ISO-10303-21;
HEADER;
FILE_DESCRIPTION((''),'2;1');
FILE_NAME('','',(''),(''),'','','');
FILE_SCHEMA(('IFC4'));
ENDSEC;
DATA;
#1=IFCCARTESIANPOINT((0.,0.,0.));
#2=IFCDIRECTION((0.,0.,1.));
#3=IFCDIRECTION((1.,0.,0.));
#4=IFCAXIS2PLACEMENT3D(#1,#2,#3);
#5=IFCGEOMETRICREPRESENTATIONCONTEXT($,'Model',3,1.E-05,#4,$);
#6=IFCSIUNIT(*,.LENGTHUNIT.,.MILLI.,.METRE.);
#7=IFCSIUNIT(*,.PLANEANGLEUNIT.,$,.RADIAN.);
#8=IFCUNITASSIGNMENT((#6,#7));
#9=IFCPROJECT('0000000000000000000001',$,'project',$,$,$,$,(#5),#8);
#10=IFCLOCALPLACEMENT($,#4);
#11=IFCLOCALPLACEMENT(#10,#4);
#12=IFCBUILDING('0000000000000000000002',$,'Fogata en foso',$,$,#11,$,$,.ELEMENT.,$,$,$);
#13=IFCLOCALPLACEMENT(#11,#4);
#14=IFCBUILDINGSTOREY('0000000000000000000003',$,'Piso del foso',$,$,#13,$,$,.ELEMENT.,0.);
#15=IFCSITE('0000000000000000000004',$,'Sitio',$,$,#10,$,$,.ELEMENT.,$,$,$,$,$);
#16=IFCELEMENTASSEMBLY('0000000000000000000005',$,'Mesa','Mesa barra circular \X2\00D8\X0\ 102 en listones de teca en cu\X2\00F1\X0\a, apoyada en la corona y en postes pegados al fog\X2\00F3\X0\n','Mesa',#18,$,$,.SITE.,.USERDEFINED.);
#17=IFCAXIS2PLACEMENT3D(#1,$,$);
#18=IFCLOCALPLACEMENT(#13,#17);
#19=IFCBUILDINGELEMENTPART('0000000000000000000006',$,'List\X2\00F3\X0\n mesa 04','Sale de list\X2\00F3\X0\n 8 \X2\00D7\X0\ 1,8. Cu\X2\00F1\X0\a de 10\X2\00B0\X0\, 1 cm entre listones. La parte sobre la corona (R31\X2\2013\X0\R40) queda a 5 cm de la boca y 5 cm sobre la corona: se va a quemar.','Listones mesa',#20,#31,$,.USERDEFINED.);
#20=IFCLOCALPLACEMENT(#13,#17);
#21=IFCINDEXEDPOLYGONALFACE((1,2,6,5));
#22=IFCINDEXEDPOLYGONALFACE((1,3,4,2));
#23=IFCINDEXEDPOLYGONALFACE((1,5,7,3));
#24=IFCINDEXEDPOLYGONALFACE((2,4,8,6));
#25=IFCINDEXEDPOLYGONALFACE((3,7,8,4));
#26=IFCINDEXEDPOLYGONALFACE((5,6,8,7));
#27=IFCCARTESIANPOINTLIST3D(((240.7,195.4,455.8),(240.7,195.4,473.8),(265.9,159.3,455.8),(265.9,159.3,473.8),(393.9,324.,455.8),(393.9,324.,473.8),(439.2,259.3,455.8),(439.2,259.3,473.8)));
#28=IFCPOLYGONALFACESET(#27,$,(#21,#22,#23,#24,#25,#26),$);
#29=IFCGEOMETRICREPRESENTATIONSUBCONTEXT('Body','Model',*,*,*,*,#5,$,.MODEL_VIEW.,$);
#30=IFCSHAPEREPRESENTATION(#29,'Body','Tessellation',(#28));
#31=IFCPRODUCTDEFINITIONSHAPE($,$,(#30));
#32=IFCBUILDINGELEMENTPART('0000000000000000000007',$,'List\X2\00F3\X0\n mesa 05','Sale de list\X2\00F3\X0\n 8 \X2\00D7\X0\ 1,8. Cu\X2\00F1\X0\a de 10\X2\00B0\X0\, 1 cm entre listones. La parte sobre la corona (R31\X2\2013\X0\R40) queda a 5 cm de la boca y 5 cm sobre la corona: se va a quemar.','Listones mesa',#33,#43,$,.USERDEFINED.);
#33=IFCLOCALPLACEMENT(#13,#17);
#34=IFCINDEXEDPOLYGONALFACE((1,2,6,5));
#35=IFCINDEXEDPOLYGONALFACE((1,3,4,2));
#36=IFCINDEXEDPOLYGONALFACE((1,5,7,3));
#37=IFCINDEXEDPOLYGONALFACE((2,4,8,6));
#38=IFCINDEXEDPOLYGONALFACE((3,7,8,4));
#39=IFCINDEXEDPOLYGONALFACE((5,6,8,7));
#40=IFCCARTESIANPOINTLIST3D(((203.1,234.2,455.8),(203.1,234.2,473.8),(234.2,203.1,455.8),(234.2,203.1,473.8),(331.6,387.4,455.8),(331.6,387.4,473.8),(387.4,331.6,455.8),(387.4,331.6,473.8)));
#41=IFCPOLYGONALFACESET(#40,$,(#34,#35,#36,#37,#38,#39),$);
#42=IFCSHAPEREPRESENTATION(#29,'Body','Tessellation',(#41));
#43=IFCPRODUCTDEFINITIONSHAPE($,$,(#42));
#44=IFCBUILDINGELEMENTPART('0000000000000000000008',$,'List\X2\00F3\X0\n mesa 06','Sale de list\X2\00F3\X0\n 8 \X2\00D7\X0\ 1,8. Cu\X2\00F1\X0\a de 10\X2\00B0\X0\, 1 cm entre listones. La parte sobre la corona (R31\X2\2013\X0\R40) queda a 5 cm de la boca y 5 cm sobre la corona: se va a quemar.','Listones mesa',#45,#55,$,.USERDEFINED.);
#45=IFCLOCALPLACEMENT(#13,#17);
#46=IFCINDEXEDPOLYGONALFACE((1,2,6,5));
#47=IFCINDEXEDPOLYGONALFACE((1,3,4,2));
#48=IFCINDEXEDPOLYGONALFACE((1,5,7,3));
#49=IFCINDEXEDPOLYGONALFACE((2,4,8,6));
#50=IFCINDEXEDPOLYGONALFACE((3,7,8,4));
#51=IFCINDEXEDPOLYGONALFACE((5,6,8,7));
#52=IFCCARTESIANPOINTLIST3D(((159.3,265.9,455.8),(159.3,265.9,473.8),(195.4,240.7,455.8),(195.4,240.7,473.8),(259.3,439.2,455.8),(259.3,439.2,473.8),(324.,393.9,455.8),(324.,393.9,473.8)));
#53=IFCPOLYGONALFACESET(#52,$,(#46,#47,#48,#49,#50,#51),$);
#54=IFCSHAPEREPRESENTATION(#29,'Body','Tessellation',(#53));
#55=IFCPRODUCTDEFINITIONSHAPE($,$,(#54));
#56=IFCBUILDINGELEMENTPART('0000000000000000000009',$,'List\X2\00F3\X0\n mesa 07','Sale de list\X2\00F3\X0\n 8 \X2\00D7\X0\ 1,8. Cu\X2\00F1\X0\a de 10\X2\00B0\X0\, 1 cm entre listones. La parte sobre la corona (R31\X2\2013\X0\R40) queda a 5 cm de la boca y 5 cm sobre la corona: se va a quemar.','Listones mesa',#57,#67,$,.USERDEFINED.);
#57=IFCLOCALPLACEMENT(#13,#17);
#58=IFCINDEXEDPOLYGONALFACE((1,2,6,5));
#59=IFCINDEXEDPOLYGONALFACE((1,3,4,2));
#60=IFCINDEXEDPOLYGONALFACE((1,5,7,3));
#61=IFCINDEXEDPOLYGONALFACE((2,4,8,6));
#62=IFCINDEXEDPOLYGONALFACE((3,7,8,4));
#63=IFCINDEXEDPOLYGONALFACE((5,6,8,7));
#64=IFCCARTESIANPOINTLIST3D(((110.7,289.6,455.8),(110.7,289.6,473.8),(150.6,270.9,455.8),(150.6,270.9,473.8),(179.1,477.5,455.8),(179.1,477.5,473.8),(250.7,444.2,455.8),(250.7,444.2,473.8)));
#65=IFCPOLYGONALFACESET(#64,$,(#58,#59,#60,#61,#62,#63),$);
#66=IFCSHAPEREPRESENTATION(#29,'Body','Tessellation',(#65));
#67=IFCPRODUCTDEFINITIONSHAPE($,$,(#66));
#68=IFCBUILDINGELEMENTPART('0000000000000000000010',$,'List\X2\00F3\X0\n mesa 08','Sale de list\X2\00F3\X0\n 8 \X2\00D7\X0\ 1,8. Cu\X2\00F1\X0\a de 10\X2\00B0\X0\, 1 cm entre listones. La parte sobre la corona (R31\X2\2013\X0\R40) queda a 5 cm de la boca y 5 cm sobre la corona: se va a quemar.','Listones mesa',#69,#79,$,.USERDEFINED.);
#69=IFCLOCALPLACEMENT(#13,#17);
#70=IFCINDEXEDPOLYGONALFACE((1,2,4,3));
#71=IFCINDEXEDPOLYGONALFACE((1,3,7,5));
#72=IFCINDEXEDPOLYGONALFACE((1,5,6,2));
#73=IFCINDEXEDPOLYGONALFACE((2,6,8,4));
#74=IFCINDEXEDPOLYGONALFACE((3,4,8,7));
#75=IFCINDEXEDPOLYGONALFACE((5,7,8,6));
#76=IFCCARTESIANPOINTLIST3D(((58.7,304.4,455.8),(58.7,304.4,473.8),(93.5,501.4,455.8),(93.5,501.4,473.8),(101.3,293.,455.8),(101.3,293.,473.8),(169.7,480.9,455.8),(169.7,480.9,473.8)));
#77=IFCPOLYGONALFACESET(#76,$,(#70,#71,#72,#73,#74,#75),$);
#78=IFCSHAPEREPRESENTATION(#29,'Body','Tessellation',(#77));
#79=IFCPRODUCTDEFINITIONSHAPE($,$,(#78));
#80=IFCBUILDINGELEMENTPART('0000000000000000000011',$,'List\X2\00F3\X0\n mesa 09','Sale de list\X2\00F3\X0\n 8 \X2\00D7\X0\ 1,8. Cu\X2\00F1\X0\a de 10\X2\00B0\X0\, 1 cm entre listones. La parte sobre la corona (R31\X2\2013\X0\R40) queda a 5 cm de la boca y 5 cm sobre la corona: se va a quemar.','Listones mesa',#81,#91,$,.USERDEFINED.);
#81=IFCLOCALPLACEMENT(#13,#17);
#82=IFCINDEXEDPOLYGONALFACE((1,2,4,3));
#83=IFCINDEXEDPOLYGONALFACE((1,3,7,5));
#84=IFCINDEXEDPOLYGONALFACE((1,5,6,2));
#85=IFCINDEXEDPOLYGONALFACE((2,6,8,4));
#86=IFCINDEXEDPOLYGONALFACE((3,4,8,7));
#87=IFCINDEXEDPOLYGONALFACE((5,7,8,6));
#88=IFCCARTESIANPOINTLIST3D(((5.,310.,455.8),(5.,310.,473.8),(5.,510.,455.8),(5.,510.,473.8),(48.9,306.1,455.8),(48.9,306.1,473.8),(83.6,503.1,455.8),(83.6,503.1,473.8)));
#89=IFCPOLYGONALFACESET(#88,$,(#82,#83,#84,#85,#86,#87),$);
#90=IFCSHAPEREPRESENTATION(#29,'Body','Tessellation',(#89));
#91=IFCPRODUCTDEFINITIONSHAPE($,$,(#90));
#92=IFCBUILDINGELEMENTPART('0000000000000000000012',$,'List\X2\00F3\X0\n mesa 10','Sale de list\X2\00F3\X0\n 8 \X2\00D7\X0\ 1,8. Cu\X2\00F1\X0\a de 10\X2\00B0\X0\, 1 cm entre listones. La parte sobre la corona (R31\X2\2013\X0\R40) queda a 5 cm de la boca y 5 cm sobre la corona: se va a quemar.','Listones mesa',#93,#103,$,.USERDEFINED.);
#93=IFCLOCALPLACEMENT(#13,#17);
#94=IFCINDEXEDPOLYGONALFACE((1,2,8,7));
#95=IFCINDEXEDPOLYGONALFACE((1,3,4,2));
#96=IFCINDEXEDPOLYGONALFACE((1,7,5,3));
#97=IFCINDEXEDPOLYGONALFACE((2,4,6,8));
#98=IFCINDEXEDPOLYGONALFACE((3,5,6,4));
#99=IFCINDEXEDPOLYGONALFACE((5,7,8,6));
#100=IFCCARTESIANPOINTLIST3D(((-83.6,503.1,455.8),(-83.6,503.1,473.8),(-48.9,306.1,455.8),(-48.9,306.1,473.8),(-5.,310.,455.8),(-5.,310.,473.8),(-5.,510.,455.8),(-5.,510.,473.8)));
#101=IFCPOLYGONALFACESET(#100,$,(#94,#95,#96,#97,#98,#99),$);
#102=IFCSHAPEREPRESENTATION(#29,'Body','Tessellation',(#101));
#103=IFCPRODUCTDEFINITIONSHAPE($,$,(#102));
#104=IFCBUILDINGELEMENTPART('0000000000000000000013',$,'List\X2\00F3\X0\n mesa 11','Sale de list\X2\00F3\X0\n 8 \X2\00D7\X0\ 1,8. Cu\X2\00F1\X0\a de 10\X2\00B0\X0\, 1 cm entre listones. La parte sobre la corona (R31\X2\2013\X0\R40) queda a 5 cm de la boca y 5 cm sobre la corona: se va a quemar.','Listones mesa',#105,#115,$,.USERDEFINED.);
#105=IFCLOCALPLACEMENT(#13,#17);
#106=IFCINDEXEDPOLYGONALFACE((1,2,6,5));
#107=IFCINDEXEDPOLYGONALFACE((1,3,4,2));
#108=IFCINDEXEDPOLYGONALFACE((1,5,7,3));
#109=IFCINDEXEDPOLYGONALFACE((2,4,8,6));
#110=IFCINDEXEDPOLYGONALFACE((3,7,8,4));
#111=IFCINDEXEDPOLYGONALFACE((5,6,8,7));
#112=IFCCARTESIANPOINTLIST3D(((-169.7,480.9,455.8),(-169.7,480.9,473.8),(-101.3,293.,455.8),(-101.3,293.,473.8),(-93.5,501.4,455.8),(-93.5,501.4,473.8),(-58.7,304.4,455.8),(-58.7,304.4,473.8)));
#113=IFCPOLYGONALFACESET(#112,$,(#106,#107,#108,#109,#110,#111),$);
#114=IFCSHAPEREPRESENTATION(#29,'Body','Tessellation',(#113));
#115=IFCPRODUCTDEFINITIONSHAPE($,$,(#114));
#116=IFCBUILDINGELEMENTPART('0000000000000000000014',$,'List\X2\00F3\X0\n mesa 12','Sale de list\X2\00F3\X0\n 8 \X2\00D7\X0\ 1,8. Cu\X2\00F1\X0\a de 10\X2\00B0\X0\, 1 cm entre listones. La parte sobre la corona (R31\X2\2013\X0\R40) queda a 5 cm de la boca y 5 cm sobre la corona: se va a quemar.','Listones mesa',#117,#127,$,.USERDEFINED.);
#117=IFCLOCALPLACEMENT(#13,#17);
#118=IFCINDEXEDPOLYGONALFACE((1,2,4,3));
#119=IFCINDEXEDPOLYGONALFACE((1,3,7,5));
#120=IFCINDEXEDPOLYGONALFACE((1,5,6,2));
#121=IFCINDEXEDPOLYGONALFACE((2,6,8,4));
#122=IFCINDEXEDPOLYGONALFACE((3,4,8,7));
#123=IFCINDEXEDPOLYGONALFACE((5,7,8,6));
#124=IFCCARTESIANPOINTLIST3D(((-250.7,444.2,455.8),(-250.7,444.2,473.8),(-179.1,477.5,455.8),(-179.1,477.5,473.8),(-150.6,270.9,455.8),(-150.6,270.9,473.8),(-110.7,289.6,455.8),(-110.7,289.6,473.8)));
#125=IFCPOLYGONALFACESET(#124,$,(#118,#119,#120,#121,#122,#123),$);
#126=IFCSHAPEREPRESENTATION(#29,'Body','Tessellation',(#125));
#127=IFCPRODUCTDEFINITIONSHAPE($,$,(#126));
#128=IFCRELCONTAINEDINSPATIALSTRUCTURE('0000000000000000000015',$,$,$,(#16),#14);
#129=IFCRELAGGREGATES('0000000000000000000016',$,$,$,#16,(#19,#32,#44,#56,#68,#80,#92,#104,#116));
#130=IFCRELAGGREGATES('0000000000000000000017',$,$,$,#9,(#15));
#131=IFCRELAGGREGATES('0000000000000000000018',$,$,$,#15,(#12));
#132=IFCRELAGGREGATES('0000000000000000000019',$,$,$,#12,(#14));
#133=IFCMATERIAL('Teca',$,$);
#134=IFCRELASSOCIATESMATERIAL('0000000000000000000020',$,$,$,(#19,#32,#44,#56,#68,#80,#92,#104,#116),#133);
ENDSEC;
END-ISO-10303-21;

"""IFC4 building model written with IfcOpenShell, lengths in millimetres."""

from ifc_helpers import new_model, si_unit, frame, origin_with_axes, place, context, subcontext, project, spatial, polyline, outline, extrude, material, element, aggregate, save


model = new_model("IFC4")

# Units and contexts
model_context = context("Model", 3, precision=1e-05, world=origin_with_axes())
body_context = subcontext(model_context, "Body", "Model", "MODEL_VIEW")
ifc_project = project(units=[si_unit("LENGTHUNIT", "METRE", prefix="MILLI"), si_unit("PLANEANGLEUNIT", "RADIAN")], contexts=[model_context])

# Site, building, storey
site_placement = place(None, origin_with_axes())
site = spatial("IfcSite", under=ifc_project, at=site_placement, Name="Sitio", CompositionType="ELEMENT")
building_placement = place(site_placement, origin_with_axes())
building = spatial("IfcBuilding", under=site, at=building_placement, Name="Fogata en foso", CompositionType="ELEMENT")
storey_placement = place(building_placement, origin_with_axes())
storey = spatial("IfcBuildingStorey", under=building, at=storey_placement, Name="Piso del foso", CompositionType="ELEMENT", Elevation=0.0)

# Element assembly
assembly_1_placement = place(storey_placement, origin_with_axes())
assembly_1 = element("IfcElementAssembly", 1, at=assembly_1_placement, inside=storey, Name="Mesa", Description="Mesa barra circular Ø 102 en listones de teca en cuña, apoyada en la corona y en postes pegados al fogón", ObjectType="Mesa", AssemblyPlace="SITE", PredefinedType="USERDEFINED")

# Building element parts
ifc_material_1 = material(Name="Teca")
building_element_part_1_placement = place(storey_placement, frame((0.0, 0.0, 455.8), z_axis=(0.0, 0.0, 1.0), x_axis=(1.0, 0.0, 0.0)))
building_element_part_1 = element("IfcBuildingElementPart", 2, at=building_element_part_1_placement, material=ifc_material_1, Name="Listón mesa 04", Description="Sale de listón 8 × 1,8. Cuña de 10°, 1 cm entre listones. La parte sobre la corona (R31–R40) queda a 5 cm de la boca y 5 cm sobre la corona: se va a quemar.", ObjectType="Listones mesa", PredefinedType="USERDEFINED", context=body_context, shape_type="SweptSolid", body=[
    extrude(outline(polyline([(265.9, 159.3), (439.2, 259.3), (393.9, 324.0), (240.7, 195.4), (265.9, 159.3)])), origin_with_axes(), (0.0, 0.0, 1.0), 18.0),
])
building_element_part_2_placement = place(storey_placement, frame((0.0, 0.0, 455.8), z_axis=(0.0, 0.0, 1.0), x_axis=(1.0, 0.0, 0.0)))
building_element_part_2 = element("IfcBuildingElementPart", 3, at=building_element_part_2_placement, material=ifc_material_1, Name="Listón mesa 05", Description="Sale de listón 8 × 1,8. Cuña de 10°, 1 cm entre listones. La parte sobre la corona (R31–R40) queda a 5 cm de la boca y 5 cm sobre la corona: se va a quemar.", ObjectType="Listones mesa", PredefinedType="USERDEFINED", context=body_context, shape_type="SweptSolid", body=[
    extrude(outline(polyline([(234.2, 203.1), (387.4, 331.6), (331.6, 387.4), (203.1, 234.2), (234.2, 203.1)])), origin_with_axes(), (0.0, 0.0, 1.0), 18.0),
])
building_element_part_3_placement = place(storey_placement, frame((0.0, 0.0, 455.8), z_axis=(0.0, 0.0, 1.0), x_axis=(1.0, 0.0, 0.0)))
building_element_part_3 = element("IfcBuildingElementPart", 4, at=building_element_part_3_placement, material=ifc_material_1, Name="Listón mesa 06", Description="Sale de listón 8 × 1,8. Cuña de 10°, 1 cm entre listones. La parte sobre la corona (R31–R40) queda a 5 cm de la boca y 5 cm sobre la corona: se va a quemar.", ObjectType="Listones mesa", PredefinedType="USERDEFINED", context=body_context, shape_type="SweptSolid", body=[
    extrude(outline(polyline([(195.4, 240.7), (324.0, 393.9), (259.3, 439.2), (159.3, 265.9), (195.4, 240.7)])), origin_with_axes(), (0.0, 0.0, 1.0), 18.0),
])
building_element_part_4_placement = place(storey_placement, frame((0.0, 0.0, 455.8), z_axis=(0.0, 0.0, 1.0), x_axis=(1.0, 0.0, 0.0)))
building_element_part_4 = element("IfcBuildingElementPart", 5, at=building_element_part_4_placement, material=ifc_material_1, Name="Listón mesa 07", Description="Sale de listón 8 × 1,8. Cuña de 10°, 1 cm entre listones. La parte sobre la corona (R31–R40) queda a 5 cm de la boca y 5 cm sobre la corona: se va a quemar.", ObjectType="Listones mesa", PredefinedType="USERDEFINED", context=body_context, shape_type="SweptSolid", body=[
    extrude(outline(polyline([(150.7, 270.9), (250.7, 444.2), (179.1, 477.5), (110.7, 289.6), (150.7, 270.9)])), origin_with_axes(), (0.0, 0.0, 1.0), 18.0),
])
building_element_part_5_placement = place(storey_placement, frame((0.0, 0.0, 455.8), z_axis=(0.0, 0.0, 1.0), x_axis=(1.0, 0.0, 0.0)))
building_element_part_5 = element("IfcBuildingElementPart", 6, at=building_element_part_5_placement, material=ifc_material_1, Name="Listón mesa 08", Description="Sale de listón 8 × 1,8. Cuña de 10°, 1 cm entre listones. La parte sobre la corona (R31–R40) queda a 5 cm de la boca y 5 cm sobre la corona: se va a quemar.", ObjectType="Listones mesa", PredefinedType="USERDEFINED", context=body_context, shape_type="SweptSolid", body=[
    extrude(outline(polyline([(101.3, 293.0), (169.7, 480.9), (93.5, 501.4), (58.7, 304.4), (101.3, 293.0)])), origin_with_axes(), (0.0, 0.0, 1.0), 18.0),
])
building_element_part_6_placement = place(storey_placement, frame((0.0, 0.0, 455.8), z_axis=(0.0, 0.0, 1.0), x_axis=(1.0, 0.0, 0.0)))
building_element_part_6 = element("IfcBuildingElementPart", 7, at=building_element_part_6_placement, material=ifc_material_1, Name="Listón mesa 09", Description="Sale de listón 8 × 1,8. Cuña de 10°, 1 cm entre listones. La parte sobre la corona (R31–R40) queda a 5 cm de la boca y 5 cm sobre la corona: se va a quemar.", ObjectType="Listones mesa", PredefinedType="USERDEFINED", context=body_context, shape_type="SweptSolid", body=[
    extrude(outline(polyline([(48.9, 306.1), (83.6, 503.1), (5.0, 510.0), (5.0, 310.0), (48.9, 306.1)])), origin_with_axes(), (0.0, 0.0, 1.0), 18.0),
])
building_element_part_7_placement = place(storey_placement, frame((0.0, 0.0, 455.8), z_axis=(0.0, 0.0, 1.0), x_axis=(1.0, 0.0, 0.0)))
building_element_part_7 = element("IfcBuildingElementPart", 8, at=building_element_part_7_placement, material=ifc_material_1, Name="Listón mesa 10", Description="Sale de listón 8 × 1,8. Cuña de 10°, 1 cm entre listones. La parte sobre la corona (R31–R40) queda a 5 cm de la boca y 5 cm sobre la corona: se va a quemar.", ObjectType="Listones mesa", PredefinedType="USERDEFINED", context=body_context, shape_type="SweptSolid", body=[
    extrude(outline(polyline([(-5.0, 310.0), (-5.0, 510.0), (-83.6, 503.1), (-48.9, 306.1), (-5.0, 310.0)])), origin_with_axes(), (0.0, 0.0, 1.0), 18.0),
])
building_element_part_8_placement = place(storey_placement, frame((0.0, 0.0, 455.8), z_axis=(0.0, 0.0, 1.0), x_axis=(1.0, 0.0, 0.0)))
building_element_part_8 = element("IfcBuildingElementPart", 9, at=building_element_part_8_placement, material=ifc_material_1, Name="Listón mesa 11", Description="Sale de listón 8 × 1,8. Cuña de 10°, 1 cm entre listones. La parte sobre la corona (R31–R40) queda a 5 cm de la boca y 5 cm sobre la corona: se va a quemar.", ObjectType="Listones mesa", PredefinedType="USERDEFINED", context=body_context, shape_type="SweptSolid", body=[
    extrude(outline(polyline([(-58.7, 304.4), (-93.5, 501.4), (-169.7, 480.9), (-101.3, 293.0), (-58.7, 304.4)])), origin_with_axes(), (0.0, 0.0, 1.0), 18.0),
])
building_element_part_9_placement = place(storey_placement, frame((0.0, 0.0, 455.8), z_axis=(0.0, 0.0, 1.0), x_axis=(1.0, 0.0, 0.0)))
building_element_part_9 = element("IfcBuildingElementPart", 10, at=building_element_part_9_placement, material=ifc_material_1, Name="Listón mesa 12", Description="Sale de listón 8 × 1,8. Cuña de 10°, 1 cm entre listones. La parte sobre la corona (R31–R40) queda a 5 cm de la boca y 5 cm sobre la corona: se va a quemar.", ObjectType="Listones mesa", PredefinedType="USERDEFINED", context=body_context, shape_type="SweptSolid", body=[
    extrude(outline(polyline([(-110.7, 289.6), (-179.1, 477.5), (-250.7, 444.2), (-150.7, 270.9), (-110.7, 289.6)])), origin_with_axes(), (0.0, 0.0, 1.0), 18.0),
])
aggregate(assembly_1, [building_element_part_1, building_element_part_2, building_element_part_3, building_element_part_4, building_element_part_5, building_element_part_6, building_element_part_7, building_element_part_8, building_element_part_9])

save(model, "model.ifc")
